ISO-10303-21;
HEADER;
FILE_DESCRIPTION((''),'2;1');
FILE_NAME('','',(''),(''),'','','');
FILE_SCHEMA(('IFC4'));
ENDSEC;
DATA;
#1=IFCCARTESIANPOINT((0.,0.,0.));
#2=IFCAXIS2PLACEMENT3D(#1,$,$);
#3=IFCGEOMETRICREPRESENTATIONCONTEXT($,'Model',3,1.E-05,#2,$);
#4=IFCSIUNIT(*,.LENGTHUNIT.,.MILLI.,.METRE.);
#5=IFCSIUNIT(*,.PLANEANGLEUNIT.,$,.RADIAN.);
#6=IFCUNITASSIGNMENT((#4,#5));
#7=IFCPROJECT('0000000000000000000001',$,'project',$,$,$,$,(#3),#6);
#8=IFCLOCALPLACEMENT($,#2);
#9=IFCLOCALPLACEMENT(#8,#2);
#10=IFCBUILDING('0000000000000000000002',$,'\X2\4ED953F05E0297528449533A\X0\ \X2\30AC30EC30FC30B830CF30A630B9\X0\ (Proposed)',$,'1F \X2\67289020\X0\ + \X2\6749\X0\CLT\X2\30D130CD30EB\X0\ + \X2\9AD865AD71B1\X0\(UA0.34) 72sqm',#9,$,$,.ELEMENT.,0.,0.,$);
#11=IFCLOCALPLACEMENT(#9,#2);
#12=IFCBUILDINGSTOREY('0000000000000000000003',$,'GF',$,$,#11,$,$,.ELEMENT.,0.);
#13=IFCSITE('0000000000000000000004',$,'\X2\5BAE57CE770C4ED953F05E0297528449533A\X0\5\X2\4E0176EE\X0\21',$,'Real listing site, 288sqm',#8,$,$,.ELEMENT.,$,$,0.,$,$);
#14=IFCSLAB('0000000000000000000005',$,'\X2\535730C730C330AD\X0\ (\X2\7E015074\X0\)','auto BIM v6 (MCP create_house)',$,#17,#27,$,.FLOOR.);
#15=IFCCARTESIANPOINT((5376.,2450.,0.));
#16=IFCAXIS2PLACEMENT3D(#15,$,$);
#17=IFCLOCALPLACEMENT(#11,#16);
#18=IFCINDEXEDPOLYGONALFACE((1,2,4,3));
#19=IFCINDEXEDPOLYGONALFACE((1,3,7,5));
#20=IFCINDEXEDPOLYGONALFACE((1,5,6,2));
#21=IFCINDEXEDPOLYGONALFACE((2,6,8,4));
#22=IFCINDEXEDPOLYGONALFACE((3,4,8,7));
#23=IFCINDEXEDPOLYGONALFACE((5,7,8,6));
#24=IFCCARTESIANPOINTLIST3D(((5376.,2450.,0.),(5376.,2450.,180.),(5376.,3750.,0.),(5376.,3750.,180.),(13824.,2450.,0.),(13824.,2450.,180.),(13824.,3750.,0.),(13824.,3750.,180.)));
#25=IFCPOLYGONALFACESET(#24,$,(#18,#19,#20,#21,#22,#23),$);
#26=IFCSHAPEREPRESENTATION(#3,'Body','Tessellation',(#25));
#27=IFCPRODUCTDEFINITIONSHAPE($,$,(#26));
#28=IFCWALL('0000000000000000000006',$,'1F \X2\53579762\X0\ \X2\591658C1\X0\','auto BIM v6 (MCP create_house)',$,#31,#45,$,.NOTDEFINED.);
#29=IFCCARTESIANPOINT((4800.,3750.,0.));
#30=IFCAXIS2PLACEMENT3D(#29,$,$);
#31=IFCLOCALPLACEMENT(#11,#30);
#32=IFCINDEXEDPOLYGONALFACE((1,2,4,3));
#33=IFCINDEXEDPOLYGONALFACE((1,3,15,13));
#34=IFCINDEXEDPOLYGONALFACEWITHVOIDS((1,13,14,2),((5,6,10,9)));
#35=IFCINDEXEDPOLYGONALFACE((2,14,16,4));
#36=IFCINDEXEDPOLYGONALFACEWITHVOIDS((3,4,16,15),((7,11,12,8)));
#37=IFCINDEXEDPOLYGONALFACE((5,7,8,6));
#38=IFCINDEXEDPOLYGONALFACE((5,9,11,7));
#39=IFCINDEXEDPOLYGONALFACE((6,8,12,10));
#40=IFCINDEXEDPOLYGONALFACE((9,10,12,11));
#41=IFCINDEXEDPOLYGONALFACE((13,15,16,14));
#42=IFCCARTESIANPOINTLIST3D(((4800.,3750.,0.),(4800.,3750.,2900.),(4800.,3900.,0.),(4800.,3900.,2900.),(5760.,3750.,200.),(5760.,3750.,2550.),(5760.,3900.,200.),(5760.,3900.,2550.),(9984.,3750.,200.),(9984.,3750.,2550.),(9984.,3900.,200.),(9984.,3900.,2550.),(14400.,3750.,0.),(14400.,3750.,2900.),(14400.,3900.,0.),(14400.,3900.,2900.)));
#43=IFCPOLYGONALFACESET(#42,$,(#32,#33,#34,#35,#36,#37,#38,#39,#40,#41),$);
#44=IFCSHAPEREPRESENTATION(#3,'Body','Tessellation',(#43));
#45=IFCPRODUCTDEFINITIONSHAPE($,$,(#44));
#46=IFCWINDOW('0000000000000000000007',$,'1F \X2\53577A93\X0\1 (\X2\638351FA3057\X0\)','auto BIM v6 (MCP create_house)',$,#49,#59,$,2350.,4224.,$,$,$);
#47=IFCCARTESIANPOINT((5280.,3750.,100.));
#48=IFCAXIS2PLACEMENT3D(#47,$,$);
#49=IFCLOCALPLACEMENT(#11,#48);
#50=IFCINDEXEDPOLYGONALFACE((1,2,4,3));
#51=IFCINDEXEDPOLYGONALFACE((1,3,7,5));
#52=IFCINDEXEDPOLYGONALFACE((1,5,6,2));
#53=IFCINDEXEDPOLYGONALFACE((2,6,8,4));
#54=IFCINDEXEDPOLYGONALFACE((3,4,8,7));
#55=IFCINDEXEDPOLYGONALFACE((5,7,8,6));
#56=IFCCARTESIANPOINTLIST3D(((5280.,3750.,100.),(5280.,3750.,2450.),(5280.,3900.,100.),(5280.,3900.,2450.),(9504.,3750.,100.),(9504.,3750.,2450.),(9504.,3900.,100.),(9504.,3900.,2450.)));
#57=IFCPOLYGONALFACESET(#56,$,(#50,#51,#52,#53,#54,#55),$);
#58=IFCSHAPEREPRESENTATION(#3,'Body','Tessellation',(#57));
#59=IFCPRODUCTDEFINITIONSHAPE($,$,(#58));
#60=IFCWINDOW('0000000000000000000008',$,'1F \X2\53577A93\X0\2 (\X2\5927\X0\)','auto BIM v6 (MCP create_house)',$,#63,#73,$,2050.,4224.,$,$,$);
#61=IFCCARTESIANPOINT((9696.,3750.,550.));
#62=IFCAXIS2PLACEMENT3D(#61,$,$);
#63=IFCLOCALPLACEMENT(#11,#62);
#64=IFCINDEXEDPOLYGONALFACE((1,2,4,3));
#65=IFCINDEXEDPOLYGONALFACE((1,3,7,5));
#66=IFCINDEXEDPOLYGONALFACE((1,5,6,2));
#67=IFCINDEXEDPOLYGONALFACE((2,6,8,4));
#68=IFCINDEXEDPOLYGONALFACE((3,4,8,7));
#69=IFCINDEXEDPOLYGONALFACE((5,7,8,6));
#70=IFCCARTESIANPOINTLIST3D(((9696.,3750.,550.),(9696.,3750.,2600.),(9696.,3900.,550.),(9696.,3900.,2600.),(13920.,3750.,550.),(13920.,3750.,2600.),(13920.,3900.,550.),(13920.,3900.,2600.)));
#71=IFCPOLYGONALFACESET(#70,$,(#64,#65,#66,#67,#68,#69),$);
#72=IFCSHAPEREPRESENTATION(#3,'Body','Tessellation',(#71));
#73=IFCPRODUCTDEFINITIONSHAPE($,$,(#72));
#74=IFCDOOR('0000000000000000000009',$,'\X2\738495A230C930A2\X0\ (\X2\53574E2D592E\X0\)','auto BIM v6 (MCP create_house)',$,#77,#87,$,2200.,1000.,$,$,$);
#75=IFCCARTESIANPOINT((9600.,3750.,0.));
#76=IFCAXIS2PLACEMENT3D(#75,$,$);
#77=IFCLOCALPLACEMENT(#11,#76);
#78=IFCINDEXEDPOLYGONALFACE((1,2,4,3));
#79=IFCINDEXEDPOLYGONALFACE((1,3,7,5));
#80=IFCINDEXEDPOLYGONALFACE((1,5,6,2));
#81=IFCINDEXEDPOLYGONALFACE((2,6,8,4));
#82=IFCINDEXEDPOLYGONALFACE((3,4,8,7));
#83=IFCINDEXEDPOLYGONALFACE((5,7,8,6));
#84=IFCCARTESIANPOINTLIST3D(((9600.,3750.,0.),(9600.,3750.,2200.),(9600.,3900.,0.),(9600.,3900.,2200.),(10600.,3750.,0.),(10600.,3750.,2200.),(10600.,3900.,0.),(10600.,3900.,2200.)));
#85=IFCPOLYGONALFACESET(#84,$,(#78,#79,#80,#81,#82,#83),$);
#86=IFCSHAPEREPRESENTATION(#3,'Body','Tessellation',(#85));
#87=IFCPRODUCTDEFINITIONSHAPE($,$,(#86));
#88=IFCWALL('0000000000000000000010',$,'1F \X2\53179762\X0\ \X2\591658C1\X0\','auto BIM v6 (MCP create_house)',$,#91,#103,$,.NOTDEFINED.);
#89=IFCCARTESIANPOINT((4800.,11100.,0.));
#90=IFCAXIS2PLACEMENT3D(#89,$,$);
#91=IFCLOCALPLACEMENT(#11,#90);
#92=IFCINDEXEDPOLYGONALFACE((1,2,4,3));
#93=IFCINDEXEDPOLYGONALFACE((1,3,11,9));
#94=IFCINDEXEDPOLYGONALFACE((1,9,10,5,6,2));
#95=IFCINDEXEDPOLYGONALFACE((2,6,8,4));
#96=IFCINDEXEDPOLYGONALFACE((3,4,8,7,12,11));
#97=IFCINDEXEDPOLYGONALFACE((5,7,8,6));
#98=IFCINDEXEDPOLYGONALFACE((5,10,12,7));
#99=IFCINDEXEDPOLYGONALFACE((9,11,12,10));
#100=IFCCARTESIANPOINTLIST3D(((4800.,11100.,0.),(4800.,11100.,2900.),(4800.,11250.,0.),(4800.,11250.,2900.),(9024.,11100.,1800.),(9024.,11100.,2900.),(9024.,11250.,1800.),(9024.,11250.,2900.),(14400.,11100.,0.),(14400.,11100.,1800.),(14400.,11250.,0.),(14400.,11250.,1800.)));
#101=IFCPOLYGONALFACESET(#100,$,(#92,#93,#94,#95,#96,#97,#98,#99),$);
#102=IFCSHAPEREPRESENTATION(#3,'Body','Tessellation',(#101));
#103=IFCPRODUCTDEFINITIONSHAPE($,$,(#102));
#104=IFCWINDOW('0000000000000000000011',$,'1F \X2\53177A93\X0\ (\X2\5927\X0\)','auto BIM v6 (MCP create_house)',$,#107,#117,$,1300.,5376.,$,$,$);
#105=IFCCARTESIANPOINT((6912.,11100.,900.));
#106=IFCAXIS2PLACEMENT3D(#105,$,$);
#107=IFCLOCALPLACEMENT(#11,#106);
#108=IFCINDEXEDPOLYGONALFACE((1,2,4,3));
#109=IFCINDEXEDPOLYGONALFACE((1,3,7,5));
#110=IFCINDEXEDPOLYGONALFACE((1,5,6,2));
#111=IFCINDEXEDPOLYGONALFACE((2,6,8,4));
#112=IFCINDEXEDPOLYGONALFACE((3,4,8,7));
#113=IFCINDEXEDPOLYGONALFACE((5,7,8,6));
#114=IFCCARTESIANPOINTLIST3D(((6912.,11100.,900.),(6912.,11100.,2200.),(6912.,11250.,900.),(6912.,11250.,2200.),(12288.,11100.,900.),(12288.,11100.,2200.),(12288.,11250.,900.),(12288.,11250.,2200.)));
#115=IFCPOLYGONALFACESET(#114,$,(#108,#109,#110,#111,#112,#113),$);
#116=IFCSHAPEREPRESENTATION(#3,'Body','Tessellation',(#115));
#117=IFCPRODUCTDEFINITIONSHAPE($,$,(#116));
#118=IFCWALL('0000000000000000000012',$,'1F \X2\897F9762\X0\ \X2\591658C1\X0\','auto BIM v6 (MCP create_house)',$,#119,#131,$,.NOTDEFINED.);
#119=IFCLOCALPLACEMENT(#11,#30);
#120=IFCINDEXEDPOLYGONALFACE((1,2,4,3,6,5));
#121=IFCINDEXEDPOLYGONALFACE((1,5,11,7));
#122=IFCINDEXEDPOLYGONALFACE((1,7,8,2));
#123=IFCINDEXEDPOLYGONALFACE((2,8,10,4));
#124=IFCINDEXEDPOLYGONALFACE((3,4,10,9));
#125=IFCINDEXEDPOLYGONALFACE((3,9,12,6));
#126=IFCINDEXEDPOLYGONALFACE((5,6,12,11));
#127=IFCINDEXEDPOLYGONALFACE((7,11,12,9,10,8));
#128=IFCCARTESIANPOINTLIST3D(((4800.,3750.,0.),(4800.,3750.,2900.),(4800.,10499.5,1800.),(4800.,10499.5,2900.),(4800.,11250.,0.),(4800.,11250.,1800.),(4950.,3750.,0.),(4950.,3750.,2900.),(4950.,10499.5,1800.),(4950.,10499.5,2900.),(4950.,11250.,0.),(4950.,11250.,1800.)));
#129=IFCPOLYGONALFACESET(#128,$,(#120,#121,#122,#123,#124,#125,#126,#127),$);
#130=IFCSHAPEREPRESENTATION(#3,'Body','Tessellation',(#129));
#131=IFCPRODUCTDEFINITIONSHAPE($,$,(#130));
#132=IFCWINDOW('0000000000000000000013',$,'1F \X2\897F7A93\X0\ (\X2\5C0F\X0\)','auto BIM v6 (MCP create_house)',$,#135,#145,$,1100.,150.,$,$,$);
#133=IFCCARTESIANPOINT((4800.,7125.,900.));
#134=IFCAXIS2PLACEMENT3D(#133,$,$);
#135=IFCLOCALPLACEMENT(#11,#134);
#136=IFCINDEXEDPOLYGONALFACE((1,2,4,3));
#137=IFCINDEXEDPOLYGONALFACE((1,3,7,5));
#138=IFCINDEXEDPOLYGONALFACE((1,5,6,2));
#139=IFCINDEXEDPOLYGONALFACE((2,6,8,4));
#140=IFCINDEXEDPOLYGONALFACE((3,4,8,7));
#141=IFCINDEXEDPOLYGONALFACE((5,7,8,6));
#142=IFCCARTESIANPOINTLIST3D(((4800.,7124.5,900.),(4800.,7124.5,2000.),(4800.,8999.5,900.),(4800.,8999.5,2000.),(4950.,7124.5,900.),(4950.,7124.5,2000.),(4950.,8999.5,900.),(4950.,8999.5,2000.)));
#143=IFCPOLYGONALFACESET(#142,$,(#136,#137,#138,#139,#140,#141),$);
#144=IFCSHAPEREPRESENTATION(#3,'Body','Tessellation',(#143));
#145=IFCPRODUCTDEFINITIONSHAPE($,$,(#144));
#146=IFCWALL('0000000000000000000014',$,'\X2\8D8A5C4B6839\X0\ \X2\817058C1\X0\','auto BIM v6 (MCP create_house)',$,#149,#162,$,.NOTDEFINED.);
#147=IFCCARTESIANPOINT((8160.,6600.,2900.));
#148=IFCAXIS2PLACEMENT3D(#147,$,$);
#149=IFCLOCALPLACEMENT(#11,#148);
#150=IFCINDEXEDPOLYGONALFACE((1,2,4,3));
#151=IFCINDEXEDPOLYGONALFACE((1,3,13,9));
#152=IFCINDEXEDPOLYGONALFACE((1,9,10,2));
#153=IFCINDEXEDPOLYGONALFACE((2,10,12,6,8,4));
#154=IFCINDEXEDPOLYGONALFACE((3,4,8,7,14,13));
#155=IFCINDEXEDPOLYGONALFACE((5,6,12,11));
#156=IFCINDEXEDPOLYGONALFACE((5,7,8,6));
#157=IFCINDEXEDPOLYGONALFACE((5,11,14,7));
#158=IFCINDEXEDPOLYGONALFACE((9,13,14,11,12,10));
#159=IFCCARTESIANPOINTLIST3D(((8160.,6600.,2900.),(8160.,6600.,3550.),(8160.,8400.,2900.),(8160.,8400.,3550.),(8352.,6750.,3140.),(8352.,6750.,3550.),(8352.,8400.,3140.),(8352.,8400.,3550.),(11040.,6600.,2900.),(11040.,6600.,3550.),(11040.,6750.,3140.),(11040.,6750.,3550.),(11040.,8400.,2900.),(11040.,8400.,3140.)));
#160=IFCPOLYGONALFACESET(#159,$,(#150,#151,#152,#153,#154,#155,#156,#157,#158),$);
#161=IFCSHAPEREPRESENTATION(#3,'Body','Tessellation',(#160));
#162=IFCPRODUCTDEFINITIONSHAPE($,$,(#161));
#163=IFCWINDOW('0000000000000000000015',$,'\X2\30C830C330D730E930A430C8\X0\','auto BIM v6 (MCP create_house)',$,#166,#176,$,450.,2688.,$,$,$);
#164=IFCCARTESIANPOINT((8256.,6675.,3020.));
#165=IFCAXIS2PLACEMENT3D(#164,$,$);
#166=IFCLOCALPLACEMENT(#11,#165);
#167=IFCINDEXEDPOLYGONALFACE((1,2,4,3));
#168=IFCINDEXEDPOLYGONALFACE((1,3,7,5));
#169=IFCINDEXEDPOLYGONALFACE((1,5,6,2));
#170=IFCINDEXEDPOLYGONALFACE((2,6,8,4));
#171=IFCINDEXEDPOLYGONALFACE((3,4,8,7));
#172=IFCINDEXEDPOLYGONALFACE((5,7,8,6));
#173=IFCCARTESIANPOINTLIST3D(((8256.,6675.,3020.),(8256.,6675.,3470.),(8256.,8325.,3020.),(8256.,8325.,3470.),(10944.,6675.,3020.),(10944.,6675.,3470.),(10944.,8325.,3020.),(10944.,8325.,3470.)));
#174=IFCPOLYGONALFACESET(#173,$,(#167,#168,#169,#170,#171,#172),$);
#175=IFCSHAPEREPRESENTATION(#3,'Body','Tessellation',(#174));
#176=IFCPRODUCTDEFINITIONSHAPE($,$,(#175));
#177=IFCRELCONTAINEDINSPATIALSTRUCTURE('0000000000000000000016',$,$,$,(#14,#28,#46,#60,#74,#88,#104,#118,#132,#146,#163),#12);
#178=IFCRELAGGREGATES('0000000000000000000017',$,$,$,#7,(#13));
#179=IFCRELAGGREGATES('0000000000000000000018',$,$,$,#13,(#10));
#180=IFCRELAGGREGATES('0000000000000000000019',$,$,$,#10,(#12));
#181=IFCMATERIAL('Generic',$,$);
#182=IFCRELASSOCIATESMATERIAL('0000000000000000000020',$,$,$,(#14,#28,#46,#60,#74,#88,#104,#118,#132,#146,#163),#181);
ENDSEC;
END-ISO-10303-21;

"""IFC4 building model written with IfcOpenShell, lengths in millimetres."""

from ifc_helpers import new_model, si_unit, frame, frame_2d, origin, place, context, project, spatial, rectangle, extrude, material, element, fill, save


model = new_model("IFC4")

# Units and contexts
model_context = context("Model", 3, precision=1e-05, world=origin())
ifc_project = project(units=[si_unit("LENGTHUNIT", "METRE", prefix="MILLI"), si_unit("PLANEANGLEUNIT", "RADIAN")], contexts=[model_context])

# Site, building, storey
site_placement = place(None, origin())
site = spatial("IfcSite", under=ifc_project, at=site_placement, Name="宮城県仙台市青葉区5丁目21", ObjectType="Real listing site, 288sqm", CompositionType="ELEMENT", RefElevation=0.0)
building_placement = place(site_placement, origin())
building = spatial("IfcBuilding", under=site, at=building_placement, Name="仙台市青葉区 ガレージハウス (Proposed)", ObjectType="1F 木造 + 杉CLTパネル + 高断熱(UA0.34) 72sqm", CompositionType="ELEMENT", ElevationOfRefHeight=0.0, ElevationOfTerrain=0.0)
storey_placement = place(building_placement, origin())
storey = spatial("IfcBuildingStorey", under=building, at=storey_placement, Name="GF", CompositionType="ELEMENT", Elevation=0.0)

# Slab
ifc_material = material(Name="Generic")
slab_1_placement = place(storey_placement, frame((5376.0, 2450.0, 0.0)))
element("IfcSlab", 1, at=slab_1_placement, inside=storey, material=ifc_material, Name="南デッキ (縁側)", Description="auto BIM v6 (MCP create_house)", PredefinedType="FLOOR", context=model_context, shape_type="SweptSolid", body=[
    extrude(rectangle(XDim=8448.0, YDim=1300.0, at=frame_2d((4224.0, 650.0))), frame((5376.0, 2450.0, 0.0)), (0.0, 0.0, 1.0), 180.0),
])

# Wall, openings, windows, door
wall_1_placement = place(storey_placement, frame((4800.0, 3750.0, 0.0)))
wall_1 = element("IfcWall", 2, at=wall_1_placement, inside=storey, material=ifc_material, Name="1F 南面 外壁", Description="auto BIM v6 (MCP create_house)", PredefinedType="NOTDEFINED", context=model_context, shape_type="SweptSolid", body=[
    extrude(rectangle(XDim=9600.0, YDim=150.0, at=frame_2d((4800.0, 75.0))), frame((4800.0, 3750.0, 0.0)), (0.0, 0.0, 1.0), 2900.0),
])
opening_1_placement = place(storey_placement, frame((5280.0, 3750.0, 100.0)))
opening_1 = element("IfcOpeningElement", 3, at=opening_1_placement, cuts=wall_1, PredefinedType="NOTDEFINED", context=model_context, shape_type="SweptSolid", body=[
    extrude(rectangle(XDim=4224.0, YDim=150.0, at=frame_2d((2112.0, 75.0))), frame((5280.0, 3750.0, 100.0)), (0.0, 0.0, 1.0), 2350.0),
])
opening_2_placement = place(storey_placement, frame((9696.0, 3750.0, 550.0)))
opening_2 = element("IfcOpeningElement", 4, at=opening_2_placement, cuts=wall_1, PredefinedType="NOTDEFINED", context=model_context, shape_type="SweptSolid", body=[
    extrude(rectangle(XDim=4224.0, YDim=150.0, at=frame_2d((2112.0, 75.0))), frame((9696.0, 3750.0, 550.0)), (0.0, 0.0, 1.0), 2050.0),
])
opening_3_placement = place(storey_placement, frame((9600.0, 3750.0, 0.0)))
opening_3 = element("IfcOpeningElement", 5, at=opening_3_placement, cuts=wall_1, PredefinedType="NOTDEFINED", context=model_context, shape_type="SweptSolid", body=[
    extrude(rectangle(XDim=1000.0, YDim=150.0, at=frame_2d((500.0, 75.0))), frame((9600.0, 3750.0, 0.0)), (0.0, 0.0, 1.0), 2200.0),
])
window_1_placement = place(storey_placement, frame((5280.0, 3750.0, 100.0)))
window_1 = element("IfcWindow", 6, at=window_1_placement, inside=storey, material=ifc_material, Name="1F 南窓1 (掃出し)", Description="auto BIM v6 (MCP create_house)", OverallHeight=2350.0, OverallWidth=4224.0, context=model_context, shape_type="SweptSolid", body=[
    extrude(rectangle(XDim=4224.0, YDim=150.0, at=frame_2d((2112.0, 75.0))), frame((5280.0, 3750.0, 100.0)), (0.0, 0.0, 1.0), 2350.0),
])
fill(opening_1, window_1)
window_2_placement = place(storey_placement, frame((9696.0, 3750.0, 550.0)))
window_2 = element("IfcWindow", 7, at=window_2_placement, inside=storey, material=ifc_material, Name="1F 南窓2 (大)", Description="auto BIM v6 (MCP create_house)", OverallHeight=2050.0, OverallWidth=4224.0, context=model_context, shape_type="SweptSolid", body=[
    extrude(rectangle(XDim=4224.0, YDim=150.0, at=frame_2d((2112.0, 75.0))), frame((9696.0, 3750.0, 550.0)), (0.0, 0.0, 1.0), 2050.0),
])
fill(opening_2, window_2)
door_placement = place(storey_placement, frame((9600.0, 3750.0, 0.0)))
door = element("IfcDoor", 8, at=door_placement, inside=storey, material=ifc_material, Name="玄関ドア (南中央)", Description="auto BIM v6 (MCP create_house)", OverallHeight=2200.0, OverallWidth=1000.0, context=model_context, shape_type="SweptSolid", body=[
    extrude(rectangle(XDim=1000.0, YDim=150.0, at=frame_2d((500.0, 75.0))), frame((9600.0, 3750.0, 0.0)), (0.0, 0.0, 1.0), 2200.0),
])
fill(opening_3, door)

# Walls, openings, windows
wall_2_placement = place(storey_placement, frame((4800.0, 11100.0, 0.0)))
wall_2 = element("IfcWall", 9, at=wall_2_placement, inside=storey, material=ifc_material, Name="1F 北面 外壁", Description="auto BIM v6 (MCP create_house)", PredefinedType="NOTDEFINED", context=model_context, shape_type="SweptSolid", body=[
    extrude(rectangle(XDim=9600.0, YDim=150.0, at=frame_2d((4800.0, 75.0))), frame((4800.0, 11100.0, 0.0)), (0.0, 0.0, 1.0), 2900.0),
])
opening_4_placement = place(storey_placement, frame((6912.0, 11100.0, 900.0)))
opening_4 = element("IfcOpeningElement", 10, at=opening_4_placement, cuts=wall_2, PredefinedType="NOTDEFINED", context=model_context, shape_type="SweptSolid", body=[
    extrude(rectangle(XDim=5376.0, YDim=150.0, at=frame_2d((2688.0, 75.0))), frame((6912.0, 11100.0, 900.0)), (0.0, 0.0, 1.0), 1300.0),
])
window_3_placement = place(storey_placement, frame((6912.0, 11100.0, 900.0)))
window_3 = element("IfcWindow", 11, at=window_3_placement, inside=storey, material=ifc_material, Name="1F 北窓 (大)", Description="auto BIM v6 (MCP create_house)", OverallHeight=1300.0, OverallWidth=5376.0, context=model_context, shape_type="SweptSolid", body=[
    extrude(rectangle(XDim=5376.0, YDim=150.0, at=frame_2d((2688.0, 75.0))), frame((6912.0, 11100.0, 900.0)), (0.0, 0.0, 1.0), 1300.0),
])
fill(opening_4, window_3)
wall_3_placement = place(storey_placement, frame((4800.0, 3750.0, 0.0)))
wall_3 = element("IfcWall", 12, at=wall_3_placement, inside=storey, material=ifc_material, Name="1F 西面 外壁", Description="auto BIM v6 (MCP create_house)", PredefinedType="NOTDEFINED", context=model_context, shape_type="SweptSolid", body=[
    extrude(rectangle(XDim=150.0, YDim=7500.0, at=frame_2d((75.0, 3750.0))), frame((4800.0, 3750.0, 0.0)), (0.0, 0.0, 1.0), 2900.0),
])
opening_5_placement = place(storey_placement, frame((4800.0, 7125.0, 900.0)))
opening_5 = element("IfcOpeningElement", 13, at=opening_5_placement, cuts=wall_3, PredefinedType="NOTDEFINED", context=model_context, shape_type="SweptSolid", body=[
    extrude(rectangle(XDim=150.0, YDim=1875.0, at=frame_2d((75.0, 937.0))), frame((4800.0, 7125.0, 900.0)), (0.0, 0.0, 1.0), 1100.0),
])
window_4_placement = place(storey_placement, frame((4800.0, 7125.0, 900.0)))
window_4 = element("IfcWindow", 14, at=window_4_placement, inside=storey, material=ifc_material, Name="1F 西窓 (小)", Description="auto BIM v6 (MCP create_house)", OverallHeight=1100.0, OverallWidth=150.0, context=model_context, shape_type="SweptSolid", body=[
    extrude(rectangle(XDim=150.0, YDim=1875.0, at=frame_2d((75.0, 937.0))), frame((4800.0, 7125.0, 900.0)), (0.0, 0.0, 1.0), 1100.0),
])
fill(opening_5, window_4)

# Wall, opening, window
wall_4_placement = place(storey_placement, frame((8160.0, 6600.0, 2900.0)))
wall_4 = element("IfcWall", 15, at=wall_4_placement, inside=storey, material=ifc_material, Name="越屋根 腰壁", Description="auto BIM v6 (MCP create_house)", PredefinedType="NOTDEFINED", context=model_context, shape_type="SweptSolid", body=[
    extrude(rectangle(XDim=2880.0, YDim=1800.0, at=frame_2d((1440.0, 900.0))), frame((8160.0, 6600.0, 2900.0)), (0.0, 0.0, 1.0), 650.0),
])
opening_6_placement = place(storey_placement, frame((8256.0, 6675.0, 3020.0)))
opening_6 = element("IfcOpeningElement", 16, at=opening_6_placement, cuts=wall_4, PredefinedType="NOTDEFINED", context=model_context, shape_type="SweptSolid", body=[
    extrude(rectangle(XDim=2688.0, YDim=1650.0, at=frame_2d((1344.0, 825.0))), frame((8256.0, 6675.0, 3020.0)), (0.0, 0.0, 1.0), 450.0),
])
window_5_placement = place(storey_placement, frame((8256.0, 6675.0, 3020.0)))
window_5 = element("IfcWindow", 17, at=window_5_placement, inside=storey, material=ifc_material, Name="トップライト", Description="auto BIM v6 (MCP create_house)", OverallHeight=450.0, OverallWidth=2688.0, context=model_context, shape_type="SweptSolid", body=[
    extrude(rectangle(XDim=2688.0, YDim=1650.0, at=frame_2d((1344.0, 825.0))), frame((8256.0, 6675.0, 3020.0)), (0.0, 0.0, 1.0), 450.0),
])
fill(opening_6, window_5)

save(model, "model.ifc")
